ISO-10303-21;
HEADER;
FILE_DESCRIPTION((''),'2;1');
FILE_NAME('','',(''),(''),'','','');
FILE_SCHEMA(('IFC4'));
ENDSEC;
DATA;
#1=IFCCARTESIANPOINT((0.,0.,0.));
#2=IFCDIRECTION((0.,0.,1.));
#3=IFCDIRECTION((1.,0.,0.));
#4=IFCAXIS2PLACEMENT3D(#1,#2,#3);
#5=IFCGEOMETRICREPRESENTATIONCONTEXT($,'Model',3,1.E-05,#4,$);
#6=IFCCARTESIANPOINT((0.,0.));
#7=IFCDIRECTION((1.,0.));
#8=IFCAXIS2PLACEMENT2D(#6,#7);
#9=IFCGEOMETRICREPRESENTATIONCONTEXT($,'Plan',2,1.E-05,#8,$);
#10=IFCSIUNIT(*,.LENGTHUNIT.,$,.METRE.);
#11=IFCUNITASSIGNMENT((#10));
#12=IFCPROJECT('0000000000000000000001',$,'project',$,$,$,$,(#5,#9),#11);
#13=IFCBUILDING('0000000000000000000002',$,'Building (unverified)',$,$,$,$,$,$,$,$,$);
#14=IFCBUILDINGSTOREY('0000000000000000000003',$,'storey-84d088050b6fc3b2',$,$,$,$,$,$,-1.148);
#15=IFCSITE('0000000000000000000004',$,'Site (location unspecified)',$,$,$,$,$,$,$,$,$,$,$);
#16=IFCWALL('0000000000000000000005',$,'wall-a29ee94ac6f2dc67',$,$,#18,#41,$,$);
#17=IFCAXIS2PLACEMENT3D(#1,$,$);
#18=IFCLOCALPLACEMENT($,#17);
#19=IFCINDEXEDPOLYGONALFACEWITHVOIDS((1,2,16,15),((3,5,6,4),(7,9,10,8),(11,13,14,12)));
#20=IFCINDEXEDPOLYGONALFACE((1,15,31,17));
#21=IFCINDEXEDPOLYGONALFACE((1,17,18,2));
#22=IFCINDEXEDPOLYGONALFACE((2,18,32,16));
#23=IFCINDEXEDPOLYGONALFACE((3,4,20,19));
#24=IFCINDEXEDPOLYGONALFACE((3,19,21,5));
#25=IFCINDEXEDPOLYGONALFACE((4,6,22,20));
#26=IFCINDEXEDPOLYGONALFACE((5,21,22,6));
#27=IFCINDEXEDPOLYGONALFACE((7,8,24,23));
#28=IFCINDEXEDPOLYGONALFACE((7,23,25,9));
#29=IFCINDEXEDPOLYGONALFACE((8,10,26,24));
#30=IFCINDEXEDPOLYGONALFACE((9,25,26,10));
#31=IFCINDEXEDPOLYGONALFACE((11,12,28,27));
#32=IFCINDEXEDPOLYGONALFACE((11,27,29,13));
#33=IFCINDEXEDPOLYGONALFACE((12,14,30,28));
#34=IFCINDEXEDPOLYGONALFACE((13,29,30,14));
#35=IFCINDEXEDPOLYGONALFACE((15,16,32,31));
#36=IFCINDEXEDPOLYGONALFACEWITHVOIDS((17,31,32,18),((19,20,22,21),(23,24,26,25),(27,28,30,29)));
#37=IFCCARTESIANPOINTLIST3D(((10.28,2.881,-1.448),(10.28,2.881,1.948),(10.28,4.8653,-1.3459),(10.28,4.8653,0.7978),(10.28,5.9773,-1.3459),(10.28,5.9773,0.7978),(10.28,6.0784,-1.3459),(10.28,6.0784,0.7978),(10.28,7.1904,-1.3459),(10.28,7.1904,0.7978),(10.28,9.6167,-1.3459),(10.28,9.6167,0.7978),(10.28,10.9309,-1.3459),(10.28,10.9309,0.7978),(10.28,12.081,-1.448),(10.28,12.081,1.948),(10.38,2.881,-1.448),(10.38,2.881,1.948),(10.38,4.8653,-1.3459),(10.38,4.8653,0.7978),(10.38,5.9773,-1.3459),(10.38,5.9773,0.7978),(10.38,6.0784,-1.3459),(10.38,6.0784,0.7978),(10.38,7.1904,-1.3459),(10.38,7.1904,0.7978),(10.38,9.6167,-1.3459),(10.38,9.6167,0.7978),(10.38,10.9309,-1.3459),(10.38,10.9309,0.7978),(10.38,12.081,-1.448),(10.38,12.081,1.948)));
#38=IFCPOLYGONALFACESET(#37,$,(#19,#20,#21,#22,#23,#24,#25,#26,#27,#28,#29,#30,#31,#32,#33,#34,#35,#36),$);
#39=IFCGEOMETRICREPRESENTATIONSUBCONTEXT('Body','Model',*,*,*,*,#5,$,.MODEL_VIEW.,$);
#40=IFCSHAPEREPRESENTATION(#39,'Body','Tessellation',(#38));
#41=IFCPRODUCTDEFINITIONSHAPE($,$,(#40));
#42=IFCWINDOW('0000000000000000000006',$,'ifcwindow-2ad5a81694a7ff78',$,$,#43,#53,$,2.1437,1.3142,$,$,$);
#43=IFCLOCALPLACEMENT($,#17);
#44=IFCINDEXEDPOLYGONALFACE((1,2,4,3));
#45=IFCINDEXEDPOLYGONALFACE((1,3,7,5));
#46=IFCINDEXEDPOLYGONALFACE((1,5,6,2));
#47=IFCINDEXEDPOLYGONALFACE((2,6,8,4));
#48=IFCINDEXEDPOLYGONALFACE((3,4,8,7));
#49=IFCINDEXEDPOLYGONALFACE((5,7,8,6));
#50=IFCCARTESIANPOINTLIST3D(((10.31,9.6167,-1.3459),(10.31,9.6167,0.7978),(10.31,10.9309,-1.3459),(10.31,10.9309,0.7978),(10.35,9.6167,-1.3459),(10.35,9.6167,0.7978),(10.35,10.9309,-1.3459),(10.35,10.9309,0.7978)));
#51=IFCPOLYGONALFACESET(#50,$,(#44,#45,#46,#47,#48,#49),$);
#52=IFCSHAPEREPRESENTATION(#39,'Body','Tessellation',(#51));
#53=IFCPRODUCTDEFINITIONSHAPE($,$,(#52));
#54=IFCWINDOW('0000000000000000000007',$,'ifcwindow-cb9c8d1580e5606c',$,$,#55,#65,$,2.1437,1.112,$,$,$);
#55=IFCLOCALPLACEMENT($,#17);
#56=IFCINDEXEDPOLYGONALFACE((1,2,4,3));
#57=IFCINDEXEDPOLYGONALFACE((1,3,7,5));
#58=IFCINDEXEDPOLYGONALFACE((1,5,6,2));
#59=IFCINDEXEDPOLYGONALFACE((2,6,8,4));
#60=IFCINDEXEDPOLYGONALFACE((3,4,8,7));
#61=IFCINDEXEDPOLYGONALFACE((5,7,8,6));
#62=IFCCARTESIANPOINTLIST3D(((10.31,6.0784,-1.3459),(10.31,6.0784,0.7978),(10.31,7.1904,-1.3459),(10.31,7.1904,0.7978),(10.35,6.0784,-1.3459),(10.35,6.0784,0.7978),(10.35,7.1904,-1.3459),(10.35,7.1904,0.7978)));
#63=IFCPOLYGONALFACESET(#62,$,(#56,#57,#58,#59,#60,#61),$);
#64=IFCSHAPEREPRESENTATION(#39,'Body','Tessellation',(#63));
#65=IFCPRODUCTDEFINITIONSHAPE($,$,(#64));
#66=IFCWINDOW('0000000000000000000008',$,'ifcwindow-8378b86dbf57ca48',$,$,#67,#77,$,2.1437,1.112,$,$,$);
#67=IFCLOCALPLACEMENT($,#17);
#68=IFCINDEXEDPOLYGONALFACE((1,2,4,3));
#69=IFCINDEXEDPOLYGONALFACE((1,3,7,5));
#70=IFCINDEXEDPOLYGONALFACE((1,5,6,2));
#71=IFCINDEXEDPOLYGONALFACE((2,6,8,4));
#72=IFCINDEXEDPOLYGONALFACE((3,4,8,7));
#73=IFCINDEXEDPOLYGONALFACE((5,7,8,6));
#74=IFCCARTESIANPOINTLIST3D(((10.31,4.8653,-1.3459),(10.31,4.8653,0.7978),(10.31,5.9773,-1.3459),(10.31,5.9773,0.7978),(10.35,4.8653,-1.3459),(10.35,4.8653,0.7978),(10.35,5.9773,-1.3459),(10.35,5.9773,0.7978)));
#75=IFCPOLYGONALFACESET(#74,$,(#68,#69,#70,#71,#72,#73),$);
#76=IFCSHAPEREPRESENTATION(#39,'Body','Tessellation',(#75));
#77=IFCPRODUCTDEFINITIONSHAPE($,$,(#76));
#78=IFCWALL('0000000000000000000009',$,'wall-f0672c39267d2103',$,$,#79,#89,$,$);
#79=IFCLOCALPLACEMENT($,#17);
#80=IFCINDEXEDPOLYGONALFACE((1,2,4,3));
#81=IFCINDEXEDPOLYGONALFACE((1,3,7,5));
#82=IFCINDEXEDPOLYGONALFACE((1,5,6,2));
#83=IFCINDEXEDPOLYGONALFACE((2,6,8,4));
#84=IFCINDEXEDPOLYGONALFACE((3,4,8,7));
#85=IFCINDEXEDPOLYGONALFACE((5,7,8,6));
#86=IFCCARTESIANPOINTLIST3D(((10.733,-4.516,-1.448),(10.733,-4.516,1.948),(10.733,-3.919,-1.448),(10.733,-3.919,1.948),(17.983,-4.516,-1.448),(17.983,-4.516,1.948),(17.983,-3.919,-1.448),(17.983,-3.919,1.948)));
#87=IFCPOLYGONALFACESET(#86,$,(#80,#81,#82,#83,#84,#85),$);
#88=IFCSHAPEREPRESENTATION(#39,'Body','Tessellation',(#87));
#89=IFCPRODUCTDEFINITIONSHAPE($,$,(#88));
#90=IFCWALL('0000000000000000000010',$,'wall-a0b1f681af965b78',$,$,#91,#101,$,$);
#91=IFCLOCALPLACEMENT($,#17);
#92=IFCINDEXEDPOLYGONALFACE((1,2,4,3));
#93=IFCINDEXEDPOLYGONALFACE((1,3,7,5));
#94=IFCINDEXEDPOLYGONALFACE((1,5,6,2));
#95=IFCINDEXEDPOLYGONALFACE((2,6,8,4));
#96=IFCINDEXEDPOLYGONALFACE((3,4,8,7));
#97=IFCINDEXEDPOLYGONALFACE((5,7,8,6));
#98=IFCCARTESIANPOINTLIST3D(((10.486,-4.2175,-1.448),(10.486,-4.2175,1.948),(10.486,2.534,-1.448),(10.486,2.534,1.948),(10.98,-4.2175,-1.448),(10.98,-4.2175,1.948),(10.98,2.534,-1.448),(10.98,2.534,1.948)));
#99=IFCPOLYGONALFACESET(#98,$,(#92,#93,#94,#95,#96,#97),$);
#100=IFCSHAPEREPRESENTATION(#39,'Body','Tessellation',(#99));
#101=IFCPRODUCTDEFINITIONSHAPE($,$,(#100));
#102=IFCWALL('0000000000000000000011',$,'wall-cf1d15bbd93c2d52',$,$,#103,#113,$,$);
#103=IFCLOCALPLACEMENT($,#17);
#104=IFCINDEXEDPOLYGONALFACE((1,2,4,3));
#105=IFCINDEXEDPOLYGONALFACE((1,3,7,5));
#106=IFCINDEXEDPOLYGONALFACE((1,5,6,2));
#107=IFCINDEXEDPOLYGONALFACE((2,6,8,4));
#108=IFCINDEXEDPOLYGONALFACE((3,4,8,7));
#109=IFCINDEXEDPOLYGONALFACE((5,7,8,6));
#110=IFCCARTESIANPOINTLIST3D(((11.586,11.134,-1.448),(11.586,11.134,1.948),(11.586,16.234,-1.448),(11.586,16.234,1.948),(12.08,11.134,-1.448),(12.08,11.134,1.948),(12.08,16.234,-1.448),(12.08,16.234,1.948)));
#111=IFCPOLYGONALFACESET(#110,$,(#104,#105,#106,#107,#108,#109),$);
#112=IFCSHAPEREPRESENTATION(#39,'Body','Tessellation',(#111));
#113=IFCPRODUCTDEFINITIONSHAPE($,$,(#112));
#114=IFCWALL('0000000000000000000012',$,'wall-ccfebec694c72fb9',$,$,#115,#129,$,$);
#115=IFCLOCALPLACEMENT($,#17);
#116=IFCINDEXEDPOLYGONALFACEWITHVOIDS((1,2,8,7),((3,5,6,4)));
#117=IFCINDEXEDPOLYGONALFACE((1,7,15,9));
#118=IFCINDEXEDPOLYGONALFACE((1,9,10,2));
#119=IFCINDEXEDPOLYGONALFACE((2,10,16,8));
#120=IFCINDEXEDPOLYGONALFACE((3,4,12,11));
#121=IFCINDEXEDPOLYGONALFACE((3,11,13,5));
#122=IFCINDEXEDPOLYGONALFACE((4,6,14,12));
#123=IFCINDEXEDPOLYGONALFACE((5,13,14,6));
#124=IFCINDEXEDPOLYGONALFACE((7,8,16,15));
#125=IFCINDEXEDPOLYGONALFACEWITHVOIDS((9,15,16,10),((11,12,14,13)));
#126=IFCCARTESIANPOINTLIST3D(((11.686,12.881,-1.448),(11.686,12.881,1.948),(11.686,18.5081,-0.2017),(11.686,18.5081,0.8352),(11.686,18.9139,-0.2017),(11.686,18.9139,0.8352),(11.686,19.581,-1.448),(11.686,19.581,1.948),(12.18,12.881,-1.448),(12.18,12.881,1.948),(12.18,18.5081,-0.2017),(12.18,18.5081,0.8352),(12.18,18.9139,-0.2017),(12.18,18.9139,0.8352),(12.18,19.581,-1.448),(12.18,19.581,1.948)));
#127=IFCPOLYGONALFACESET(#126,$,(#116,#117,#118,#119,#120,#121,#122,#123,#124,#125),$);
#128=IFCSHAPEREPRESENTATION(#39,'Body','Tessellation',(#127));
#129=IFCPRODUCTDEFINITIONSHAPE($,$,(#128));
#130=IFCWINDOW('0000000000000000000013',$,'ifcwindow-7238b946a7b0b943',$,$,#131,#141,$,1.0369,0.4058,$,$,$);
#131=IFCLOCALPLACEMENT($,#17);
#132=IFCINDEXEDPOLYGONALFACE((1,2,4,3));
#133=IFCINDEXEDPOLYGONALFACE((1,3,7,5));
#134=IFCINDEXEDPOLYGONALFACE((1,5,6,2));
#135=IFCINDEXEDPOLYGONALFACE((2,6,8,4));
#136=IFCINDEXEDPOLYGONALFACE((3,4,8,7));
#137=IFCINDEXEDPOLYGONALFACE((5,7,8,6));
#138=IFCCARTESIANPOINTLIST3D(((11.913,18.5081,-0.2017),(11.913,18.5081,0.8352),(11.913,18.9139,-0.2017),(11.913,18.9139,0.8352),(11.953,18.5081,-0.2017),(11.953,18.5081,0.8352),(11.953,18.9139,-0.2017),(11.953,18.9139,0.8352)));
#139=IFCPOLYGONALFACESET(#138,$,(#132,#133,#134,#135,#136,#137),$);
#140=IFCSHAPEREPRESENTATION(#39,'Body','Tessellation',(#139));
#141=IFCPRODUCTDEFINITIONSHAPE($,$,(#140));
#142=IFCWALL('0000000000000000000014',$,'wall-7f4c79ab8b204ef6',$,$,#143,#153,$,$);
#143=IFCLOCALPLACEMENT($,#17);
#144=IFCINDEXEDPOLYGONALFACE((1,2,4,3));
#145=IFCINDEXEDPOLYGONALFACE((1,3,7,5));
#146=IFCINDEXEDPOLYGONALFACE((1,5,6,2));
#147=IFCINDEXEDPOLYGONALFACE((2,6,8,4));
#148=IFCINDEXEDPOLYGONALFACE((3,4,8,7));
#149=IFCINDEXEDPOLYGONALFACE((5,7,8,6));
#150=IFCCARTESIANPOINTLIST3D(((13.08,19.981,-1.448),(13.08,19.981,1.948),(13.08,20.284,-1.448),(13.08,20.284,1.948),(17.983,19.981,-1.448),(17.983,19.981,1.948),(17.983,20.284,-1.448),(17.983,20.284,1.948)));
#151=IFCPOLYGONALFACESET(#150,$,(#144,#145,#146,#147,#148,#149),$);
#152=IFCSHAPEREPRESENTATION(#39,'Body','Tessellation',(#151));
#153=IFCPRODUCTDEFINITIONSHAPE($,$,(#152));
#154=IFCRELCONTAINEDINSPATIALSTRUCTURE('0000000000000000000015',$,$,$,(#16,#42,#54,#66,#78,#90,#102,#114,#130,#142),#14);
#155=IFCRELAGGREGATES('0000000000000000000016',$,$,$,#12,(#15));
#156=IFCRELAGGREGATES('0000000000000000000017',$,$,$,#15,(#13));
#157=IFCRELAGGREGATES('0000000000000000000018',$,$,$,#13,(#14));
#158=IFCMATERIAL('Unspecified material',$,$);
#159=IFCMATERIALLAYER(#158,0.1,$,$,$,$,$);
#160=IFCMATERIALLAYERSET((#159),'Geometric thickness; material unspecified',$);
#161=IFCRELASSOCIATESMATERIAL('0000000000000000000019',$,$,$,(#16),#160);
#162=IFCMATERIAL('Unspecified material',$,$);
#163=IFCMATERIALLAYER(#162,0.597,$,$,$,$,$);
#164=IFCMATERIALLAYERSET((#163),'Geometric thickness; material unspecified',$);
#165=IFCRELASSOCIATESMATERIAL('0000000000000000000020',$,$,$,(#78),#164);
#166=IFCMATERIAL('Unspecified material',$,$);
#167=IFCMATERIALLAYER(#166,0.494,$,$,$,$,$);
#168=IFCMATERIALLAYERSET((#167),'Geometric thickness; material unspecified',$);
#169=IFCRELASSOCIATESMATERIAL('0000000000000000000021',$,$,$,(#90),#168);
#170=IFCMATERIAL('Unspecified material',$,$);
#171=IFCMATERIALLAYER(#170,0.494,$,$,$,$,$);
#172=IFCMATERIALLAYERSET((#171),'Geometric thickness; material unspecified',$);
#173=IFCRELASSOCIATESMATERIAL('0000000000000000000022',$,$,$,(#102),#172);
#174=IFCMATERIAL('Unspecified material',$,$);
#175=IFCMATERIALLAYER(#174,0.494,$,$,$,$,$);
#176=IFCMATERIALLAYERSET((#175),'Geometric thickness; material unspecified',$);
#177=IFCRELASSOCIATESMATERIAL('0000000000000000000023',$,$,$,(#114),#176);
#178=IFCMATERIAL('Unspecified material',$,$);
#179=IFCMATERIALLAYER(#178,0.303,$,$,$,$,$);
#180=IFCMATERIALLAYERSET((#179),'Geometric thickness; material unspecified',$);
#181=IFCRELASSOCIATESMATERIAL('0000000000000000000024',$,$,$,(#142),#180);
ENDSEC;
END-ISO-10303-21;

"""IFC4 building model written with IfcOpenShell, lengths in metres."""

from ifc_helpers import new_model, si_unit, frame, origin_with_axes, origin_2d_with_axis, place, context, subcontext, project, spatial, indexed_curve, outline, extrude, material, layer, layer_set, layer_usage, element, fill, save


model = new_model("IFC4")

# Units and contexts
model_context = context("Model", 3, precision=1e-05, world=origin_with_axes())
plan_context = context("Plan", 2, precision=1e-05, world=origin_2d_with_axis())
body_context = subcontext(model_context, "Body", "Model", "MODEL_VIEW")
ifc_project = project(units=[si_unit("LENGTHUNIT", "METRE")], contexts=[model_context, plan_context])

# Site, building, storey
site = spatial("IfcSite", under=ifc_project, Name="Site (location unspecified)")
building = spatial("IfcBuilding", under=site, Name="Building (unverified)")
storey = spatial("IfcBuildingStorey", under=building, Name="storey-84d088050b6fc3b2", Elevation=-1.148)

# Wall, openings, windows
ifc_material_1 = material(Name="Unspecified material")
ifc_layer_1 = layer(ifc_material_1, 0.1)
ifc_layer_set_1 = layer_set([ifc_layer_1], Name="Geometric thickness; material unspecified")
ifc_layer_usage_1 = layer_usage(ifc_layer_set_1, "AXIS2", "POSITIVE", -0.05)
wall_1_placement = place(None, frame((10.33, 12.081, -1.448), z_axis=(0.0, 0.0, 1.0), x_axis=(0.0, -1.0, 0.0)))
wall_1 = element("IfcWall", 1, at=wall_1_placement, inside=storey, material=ifc_layer_usage_1, Name="wall-a29ee94ac6f2dc67", context=body_context, shape_type="SweptSolid", body=[
    extrude(outline(indexed_curve([(0.0, 0.0), (0.0, 0.1), (9.2, 0.1), (9.2, 0.0), (0.0, 0.0)], self_intersect=False)), frame((0.0, -0.05, 0.0), z_axis=(0.0, 0.0, 1.0), x_axis=(1.0, 0.0, 0.0)), (0.0, 0.0, 1.0), 3.396),
])
opening_1_placement = place(wall_1_placement, frame((1.1501, -0.06, 0.1021), z_axis=(0.0, 0.0, 1.0), x_axis=(1.0, 0.0, 0.0)))
opening_1 = element("IfcOpeningElement", 2, at=opening_1_placement, cuts=wall_1, context=body_context, shape_type="SweptSolid", body=[
    extrude(outline(indexed_curve([(0.0, 0.0), (0.0, 0.12), (1.3142, 0.12), (1.3142, 0.0), (0.0, 0.0)], self_intersect=False)), origin_with_axes(), (0.0, 0.0, 1.0), 2.1437),
])
opening_2_placement = place(wall_1_placement, frame((4.8906, -0.06, 0.1021), z_axis=(0.0, 0.0, 1.0), x_axis=(1.0, 0.0, 0.0)))
opening_2 = element("IfcOpeningElement", 3, at=opening_2_placement, cuts=wall_1, context=body_context, shape_type="SweptSolid", body=[
    extrude(outline(indexed_curve([(0.0, 0.0), (0.0, 0.12), (1.112, 0.12), (1.112, 0.0), (0.0, 0.0)], self_intersect=False)), origin_with_axes(), (0.0, 0.0, 1.0), 2.1437),
])
opening_3_placement = place(wall_1_placement, frame((6.1037, -0.06, 0.1021), z_axis=(0.0, 0.0, 1.0), x_axis=(1.0, 0.0, 0.0)))
opening_3 = element("IfcOpeningElement", 4, at=opening_3_placement, cuts=wall_1, context=body_context, shape_type="SweptSolid", body=[
    extrude(outline(indexed_curve([(0.0, 0.0), (0.0, 0.12), (1.112, 0.12), (1.112, 0.0), (0.0, 0.0)], self_intersect=False)), origin_with_axes(), (0.0, 0.0, 1.0), 2.1437),
])
window_1_placement = place(None, frame((10.31, 10.9309, -1.3459), z_axis=(0.0, 0.0, 1.0), x_axis=(0.0, -1.0, 0.0)))
window_1 = element("IfcWindow", 5, at=window_1_placement, inside=storey, Name="ifcwindow-2ad5a81694a7ff78", OverallHeight=2.1437, OverallWidth=1.3142, context=body_context, shape_type="SweptSolid", body=[
    extrude(outline(indexed_curve([(0.0, 0.0), (0.0, 0.04), (1.3142, 0.04), (1.3142, 0.0), (0.0, 0.0)], self_intersect=False)), origin_with_axes(), (0.0, 0.0, 1.0), 2.1437),
])
fill(opening_1, window_1)
window_2_placement = place(None, frame((10.31, 7.1904, -1.3459), z_axis=(0.0, 0.0, 1.0), x_axis=(0.0, -1.0, 0.0)))
window_2 = element("IfcWindow", 6, at=window_2_placement, inside=storey, Name="ifcwindow-cb9c8d1580e5606c", OverallHeight=2.1437, OverallWidth=1.112, context=body_context, shape_type="SweptSolid", body=[
    extrude(outline(indexed_curve([(0.0, 0.0), (0.0, 0.04), (1.112, 0.04), (1.112, 0.0), (0.0, 0.0)], self_intersect=False)), origin_with_axes(), (0.0, 0.0, 1.0), 2.1437),
])
fill(opening_2, window_2)
window_3_placement = place(None, frame((10.31, 5.9773, -1.3459), z_axis=(0.0, 0.0, 1.0), x_axis=(0.0, -1.0, 0.0)))
window_3 = element("IfcWindow", 7, at=window_3_placement, inside=storey, Name="ifcwindow-8378b86dbf57ca48", OverallHeight=2.1437, OverallWidth=1.112, context=body_context, shape_type="SweptSolid", body=[
    extrude(outline(indexed_curve([(0.0, 0.0), (0.0, 0.04), (1.112, 0.04), (1.112, 0.0), (0.0, 0.0)], self_intersect=False)), origin_with_axes(), (0.0, 0.0, 1.0), 2.1437),
])
fill(opening_3, window_3)

# Walls
ifc_material_2 = material(Name="Unspecified material")
ifc_layer_2 = layer(ifc_material_2, 0.597)
ifc_layer_set_2 = layer_set([ifc_layer_2], Name="Geometric thickness; material unspecified")
ifc_layer_usage_2 = layer_usage(ifc_layer_set_2, "AXIS2", "POSITIVE", -0.2985)
wall_2_placement = place(None, frame((17.983, -4.2175, -1.448), z_axis=(0.0, 0.0, 1.0), x_axis=(-1.0, 0.0, 0.0)))
element("IfcWall", 8, at=wall_2_placement, inside=storey, material=ifc_layer_usage_2, Name="wall-f0672c39267d2103", context=body_context, shape_type="SweptSolid", body=[
    extrude(outline(indexed_curve([(0.0, 0.0), (0.0, 0.597), (7.25, 0.597), (7.25, 0.0), (0.0, 0.0)], self_intersect=False)), frame((0.0, -0.2985, 0.0), z_axis=(0.0, 0.0, 1.0), x_axis=(1.0, 0.0, 0.0)), (0.0, 0.0, 1.0), 3.396),
])
ifc_material_3 = material(Name="Unspecified material")
ifc_layer_3 = layer(ifc_material_3, 0.494)
ifc_layer_set_3 = layer_set([ifc_layer_3], Name="Geometric thickness; material unspecified")
ifc_layer_usage_3 = layer_usage(ifc_layer_set_3, "AXIS2", "POSITIVE", -0.247)
wall_3_placement = place(None, frame((10.733, -4.2175, -1.448), z_axis=(0.0, 0.0, 1.0), x_axis=(0.0, 1.0, 0.0)))
element("IfcWall", 9, at=wall_3_placement, inside=storey, material=ifc_layer_usage_3, Name="wall-a0b1f681af965b78", context=body_context, shape_type="SweptSolid", body=[
    extrude(outline(indexed_curve([(0.0, 0.0), (0.0, 0.494), (6.7515, 0.494), (6.7515, 0.0), (0.0, 0.0)], self_intersect=False)), frame((0.0, -0.247, 0.0), z_axis=(0.0, 0.0, 1.0), x_axis=(1.0, 0.0, 0.0)), (0.0, 0.0, 1.0), 3.396),
])
ifc_material_4 = material(Name="Unspecified material")
ifc_layer_4 = layer(ifc_material_4, 0.494)
ifc_layer_set_4 = layer_set([ifc_layer_4], Name="Geometric thickness; material unspecified")
ifc_layer_usage_4 = layer_usage(ifc_layer_set_4, "AXIS2", "POSITIVE", -0.247)
wall_4_placement = place(None, frame((11.833, 11.134, -1.448), z_axis=(0.0, 0.0, 1.0), x_axis=(0.0, 1.0, 0.0)))
element("IfcWall", 10, at=wall_4_placement, inside=storey, material=ifc_layer_usage_4, Name="wall-cf1d15bbd93c2d52", context=body_context, shape_type="SweptSolid", body=[
    extrude(outline(indexed_curve([(0.0, 0.0), (0.0, 0.494), (5.1, 0.494), (5.1, 0.0), (0.0, 0.0)], self_intersect=False)), frame((0.0, -0.247, 0.0), z_axis=(0.0, 0.0, 1.0), x_axis=(1.0, 0.0, 0.0)), (0.0, 0.0, 1.0), 3.396),
])

# Wall, opening, window
ifc_material_5 = material(Name="Unspecified material")
ifc_layer_5 = layer(ifc_material_5, 0.494)
ifc_layer_set_5 = layer_set([ifc_layer_5], Name="Geometric thickness; material unspecified")
ifc_layer_usage_5 = layer_usage(ifc_layer_set_5, "AXIS2", "POSITIVE", -0.247)
wall_5_placement = place(None, frame((11.933, 12.881, -1.448), z_axis=(0.0, 0.0, 1.0), x_axis=(0.0, 1.0, 0.0)))
wall_5 = element("IfcWall", 11, at=wall_5_placement, inside=storey, material=ifc_layer_usage_5, Name="wall-ccfebec694c72fb9", context=body_context, shape_type="SweptSolid", body=[
    extrude(outline(indexed_curve([(0.0, 0.0), (0.0, 0.494), (6.7, 0.494), (6.7, 0.0), (0.0, 0.0)], self_intersect=False)), frame((0.0, -0.247, 0.0), z_axis=(0.0, 0.0, 1.0), x_axis=(1.0, 0.0, 0.0)), (0.0, 0.0, 1.0), 3.396),
])
opening_4_placement = place(wall_5_placement, frame((5.6271, -0.257, 1.2463), z_axis=(0.0, 0.0, 1.0), x_axis=(1.0, 0.0, 0.0)))
opening_4 = element("IfcOpeningElement", 12, at=opening_4_placement, cuts=wall_5, context=body_context, shape_type="SweptSolid", body=[
    extrude(outline(indexed_curve([(0.0, 0.0), (0.0, 0.514), (0.4058, 0.514), (0.4058, 0.0), (0.0, 0.0)], self_intersect=False)), origin_with_axes(), (0.0, 0.0, 1.0), 1.0369),
])
window_4_placement = place(None, frame((11.953, 18.5081, -0.2017), z_axis=(0.0, 0.0, 1.0), x_axis=(0.0, 1.0, 0.0)))
window_4 = element("IfcWindow", 13, at=window_4_placement, inside=storey, Name="ifcwindow-7238b946a7b0b943", OverallHeight=1.0369, OverallWidth=0.4058, context=body_context, shape_type="SweptSolid", body=[
    extrude(outline(indexed_curve([(0.0, 0.0), (0.0, 0.04), (0.4058, 0.04), (0.4058, 0.0), (0.0, 0.0)], self_intersect=False)), origin_with_axes(), (0.0, 0.0, 1.0), 1.0369),
])
fill(opening_4, window_4)

# Wall
ifc_material_6 = material(Name="Unspecified material")
ifc_layer_6 = layer(ifc_material_6, 0.303)
ifc_layer_set_6 = layer_set([ifc_layer_6], Name="Geometric thickness; material unspecified")
ifc_layer_usage_6 = layer_usage(ifc_layer_set_6, "AXIS2", "POSITIVE", -0.1515)
wall_6_placement = place(None, frame((13.08, 20.1325, -1.448), z_axis=(0.0, 0.0, 1.0), x_axis=(1.0, 0.0, 0.0)))
element("IfcWall", 14, at=wall_6_placement, inside=storey, material=ifc_layer_usage_6, Name="wall-7f4c79ab8b204ef6", context=body_context, shape_type="SweptSolid", body=[
    extrude(outline(indexed_curve([(0.0, 0.0), (0.0, 0.303), (4.903, 0.303), (4.903, 0.0), (0.0, 0.0)], self_intersect=False)), frame((0.0, -0.1515, 0.0), z_axis=(0.0, 0.0, 1.0), x_axis=(1.0, 0.0, 0.0)), (0.0, 0.0, 1.0), 3.396),
])

save(model, "model.ifc")
